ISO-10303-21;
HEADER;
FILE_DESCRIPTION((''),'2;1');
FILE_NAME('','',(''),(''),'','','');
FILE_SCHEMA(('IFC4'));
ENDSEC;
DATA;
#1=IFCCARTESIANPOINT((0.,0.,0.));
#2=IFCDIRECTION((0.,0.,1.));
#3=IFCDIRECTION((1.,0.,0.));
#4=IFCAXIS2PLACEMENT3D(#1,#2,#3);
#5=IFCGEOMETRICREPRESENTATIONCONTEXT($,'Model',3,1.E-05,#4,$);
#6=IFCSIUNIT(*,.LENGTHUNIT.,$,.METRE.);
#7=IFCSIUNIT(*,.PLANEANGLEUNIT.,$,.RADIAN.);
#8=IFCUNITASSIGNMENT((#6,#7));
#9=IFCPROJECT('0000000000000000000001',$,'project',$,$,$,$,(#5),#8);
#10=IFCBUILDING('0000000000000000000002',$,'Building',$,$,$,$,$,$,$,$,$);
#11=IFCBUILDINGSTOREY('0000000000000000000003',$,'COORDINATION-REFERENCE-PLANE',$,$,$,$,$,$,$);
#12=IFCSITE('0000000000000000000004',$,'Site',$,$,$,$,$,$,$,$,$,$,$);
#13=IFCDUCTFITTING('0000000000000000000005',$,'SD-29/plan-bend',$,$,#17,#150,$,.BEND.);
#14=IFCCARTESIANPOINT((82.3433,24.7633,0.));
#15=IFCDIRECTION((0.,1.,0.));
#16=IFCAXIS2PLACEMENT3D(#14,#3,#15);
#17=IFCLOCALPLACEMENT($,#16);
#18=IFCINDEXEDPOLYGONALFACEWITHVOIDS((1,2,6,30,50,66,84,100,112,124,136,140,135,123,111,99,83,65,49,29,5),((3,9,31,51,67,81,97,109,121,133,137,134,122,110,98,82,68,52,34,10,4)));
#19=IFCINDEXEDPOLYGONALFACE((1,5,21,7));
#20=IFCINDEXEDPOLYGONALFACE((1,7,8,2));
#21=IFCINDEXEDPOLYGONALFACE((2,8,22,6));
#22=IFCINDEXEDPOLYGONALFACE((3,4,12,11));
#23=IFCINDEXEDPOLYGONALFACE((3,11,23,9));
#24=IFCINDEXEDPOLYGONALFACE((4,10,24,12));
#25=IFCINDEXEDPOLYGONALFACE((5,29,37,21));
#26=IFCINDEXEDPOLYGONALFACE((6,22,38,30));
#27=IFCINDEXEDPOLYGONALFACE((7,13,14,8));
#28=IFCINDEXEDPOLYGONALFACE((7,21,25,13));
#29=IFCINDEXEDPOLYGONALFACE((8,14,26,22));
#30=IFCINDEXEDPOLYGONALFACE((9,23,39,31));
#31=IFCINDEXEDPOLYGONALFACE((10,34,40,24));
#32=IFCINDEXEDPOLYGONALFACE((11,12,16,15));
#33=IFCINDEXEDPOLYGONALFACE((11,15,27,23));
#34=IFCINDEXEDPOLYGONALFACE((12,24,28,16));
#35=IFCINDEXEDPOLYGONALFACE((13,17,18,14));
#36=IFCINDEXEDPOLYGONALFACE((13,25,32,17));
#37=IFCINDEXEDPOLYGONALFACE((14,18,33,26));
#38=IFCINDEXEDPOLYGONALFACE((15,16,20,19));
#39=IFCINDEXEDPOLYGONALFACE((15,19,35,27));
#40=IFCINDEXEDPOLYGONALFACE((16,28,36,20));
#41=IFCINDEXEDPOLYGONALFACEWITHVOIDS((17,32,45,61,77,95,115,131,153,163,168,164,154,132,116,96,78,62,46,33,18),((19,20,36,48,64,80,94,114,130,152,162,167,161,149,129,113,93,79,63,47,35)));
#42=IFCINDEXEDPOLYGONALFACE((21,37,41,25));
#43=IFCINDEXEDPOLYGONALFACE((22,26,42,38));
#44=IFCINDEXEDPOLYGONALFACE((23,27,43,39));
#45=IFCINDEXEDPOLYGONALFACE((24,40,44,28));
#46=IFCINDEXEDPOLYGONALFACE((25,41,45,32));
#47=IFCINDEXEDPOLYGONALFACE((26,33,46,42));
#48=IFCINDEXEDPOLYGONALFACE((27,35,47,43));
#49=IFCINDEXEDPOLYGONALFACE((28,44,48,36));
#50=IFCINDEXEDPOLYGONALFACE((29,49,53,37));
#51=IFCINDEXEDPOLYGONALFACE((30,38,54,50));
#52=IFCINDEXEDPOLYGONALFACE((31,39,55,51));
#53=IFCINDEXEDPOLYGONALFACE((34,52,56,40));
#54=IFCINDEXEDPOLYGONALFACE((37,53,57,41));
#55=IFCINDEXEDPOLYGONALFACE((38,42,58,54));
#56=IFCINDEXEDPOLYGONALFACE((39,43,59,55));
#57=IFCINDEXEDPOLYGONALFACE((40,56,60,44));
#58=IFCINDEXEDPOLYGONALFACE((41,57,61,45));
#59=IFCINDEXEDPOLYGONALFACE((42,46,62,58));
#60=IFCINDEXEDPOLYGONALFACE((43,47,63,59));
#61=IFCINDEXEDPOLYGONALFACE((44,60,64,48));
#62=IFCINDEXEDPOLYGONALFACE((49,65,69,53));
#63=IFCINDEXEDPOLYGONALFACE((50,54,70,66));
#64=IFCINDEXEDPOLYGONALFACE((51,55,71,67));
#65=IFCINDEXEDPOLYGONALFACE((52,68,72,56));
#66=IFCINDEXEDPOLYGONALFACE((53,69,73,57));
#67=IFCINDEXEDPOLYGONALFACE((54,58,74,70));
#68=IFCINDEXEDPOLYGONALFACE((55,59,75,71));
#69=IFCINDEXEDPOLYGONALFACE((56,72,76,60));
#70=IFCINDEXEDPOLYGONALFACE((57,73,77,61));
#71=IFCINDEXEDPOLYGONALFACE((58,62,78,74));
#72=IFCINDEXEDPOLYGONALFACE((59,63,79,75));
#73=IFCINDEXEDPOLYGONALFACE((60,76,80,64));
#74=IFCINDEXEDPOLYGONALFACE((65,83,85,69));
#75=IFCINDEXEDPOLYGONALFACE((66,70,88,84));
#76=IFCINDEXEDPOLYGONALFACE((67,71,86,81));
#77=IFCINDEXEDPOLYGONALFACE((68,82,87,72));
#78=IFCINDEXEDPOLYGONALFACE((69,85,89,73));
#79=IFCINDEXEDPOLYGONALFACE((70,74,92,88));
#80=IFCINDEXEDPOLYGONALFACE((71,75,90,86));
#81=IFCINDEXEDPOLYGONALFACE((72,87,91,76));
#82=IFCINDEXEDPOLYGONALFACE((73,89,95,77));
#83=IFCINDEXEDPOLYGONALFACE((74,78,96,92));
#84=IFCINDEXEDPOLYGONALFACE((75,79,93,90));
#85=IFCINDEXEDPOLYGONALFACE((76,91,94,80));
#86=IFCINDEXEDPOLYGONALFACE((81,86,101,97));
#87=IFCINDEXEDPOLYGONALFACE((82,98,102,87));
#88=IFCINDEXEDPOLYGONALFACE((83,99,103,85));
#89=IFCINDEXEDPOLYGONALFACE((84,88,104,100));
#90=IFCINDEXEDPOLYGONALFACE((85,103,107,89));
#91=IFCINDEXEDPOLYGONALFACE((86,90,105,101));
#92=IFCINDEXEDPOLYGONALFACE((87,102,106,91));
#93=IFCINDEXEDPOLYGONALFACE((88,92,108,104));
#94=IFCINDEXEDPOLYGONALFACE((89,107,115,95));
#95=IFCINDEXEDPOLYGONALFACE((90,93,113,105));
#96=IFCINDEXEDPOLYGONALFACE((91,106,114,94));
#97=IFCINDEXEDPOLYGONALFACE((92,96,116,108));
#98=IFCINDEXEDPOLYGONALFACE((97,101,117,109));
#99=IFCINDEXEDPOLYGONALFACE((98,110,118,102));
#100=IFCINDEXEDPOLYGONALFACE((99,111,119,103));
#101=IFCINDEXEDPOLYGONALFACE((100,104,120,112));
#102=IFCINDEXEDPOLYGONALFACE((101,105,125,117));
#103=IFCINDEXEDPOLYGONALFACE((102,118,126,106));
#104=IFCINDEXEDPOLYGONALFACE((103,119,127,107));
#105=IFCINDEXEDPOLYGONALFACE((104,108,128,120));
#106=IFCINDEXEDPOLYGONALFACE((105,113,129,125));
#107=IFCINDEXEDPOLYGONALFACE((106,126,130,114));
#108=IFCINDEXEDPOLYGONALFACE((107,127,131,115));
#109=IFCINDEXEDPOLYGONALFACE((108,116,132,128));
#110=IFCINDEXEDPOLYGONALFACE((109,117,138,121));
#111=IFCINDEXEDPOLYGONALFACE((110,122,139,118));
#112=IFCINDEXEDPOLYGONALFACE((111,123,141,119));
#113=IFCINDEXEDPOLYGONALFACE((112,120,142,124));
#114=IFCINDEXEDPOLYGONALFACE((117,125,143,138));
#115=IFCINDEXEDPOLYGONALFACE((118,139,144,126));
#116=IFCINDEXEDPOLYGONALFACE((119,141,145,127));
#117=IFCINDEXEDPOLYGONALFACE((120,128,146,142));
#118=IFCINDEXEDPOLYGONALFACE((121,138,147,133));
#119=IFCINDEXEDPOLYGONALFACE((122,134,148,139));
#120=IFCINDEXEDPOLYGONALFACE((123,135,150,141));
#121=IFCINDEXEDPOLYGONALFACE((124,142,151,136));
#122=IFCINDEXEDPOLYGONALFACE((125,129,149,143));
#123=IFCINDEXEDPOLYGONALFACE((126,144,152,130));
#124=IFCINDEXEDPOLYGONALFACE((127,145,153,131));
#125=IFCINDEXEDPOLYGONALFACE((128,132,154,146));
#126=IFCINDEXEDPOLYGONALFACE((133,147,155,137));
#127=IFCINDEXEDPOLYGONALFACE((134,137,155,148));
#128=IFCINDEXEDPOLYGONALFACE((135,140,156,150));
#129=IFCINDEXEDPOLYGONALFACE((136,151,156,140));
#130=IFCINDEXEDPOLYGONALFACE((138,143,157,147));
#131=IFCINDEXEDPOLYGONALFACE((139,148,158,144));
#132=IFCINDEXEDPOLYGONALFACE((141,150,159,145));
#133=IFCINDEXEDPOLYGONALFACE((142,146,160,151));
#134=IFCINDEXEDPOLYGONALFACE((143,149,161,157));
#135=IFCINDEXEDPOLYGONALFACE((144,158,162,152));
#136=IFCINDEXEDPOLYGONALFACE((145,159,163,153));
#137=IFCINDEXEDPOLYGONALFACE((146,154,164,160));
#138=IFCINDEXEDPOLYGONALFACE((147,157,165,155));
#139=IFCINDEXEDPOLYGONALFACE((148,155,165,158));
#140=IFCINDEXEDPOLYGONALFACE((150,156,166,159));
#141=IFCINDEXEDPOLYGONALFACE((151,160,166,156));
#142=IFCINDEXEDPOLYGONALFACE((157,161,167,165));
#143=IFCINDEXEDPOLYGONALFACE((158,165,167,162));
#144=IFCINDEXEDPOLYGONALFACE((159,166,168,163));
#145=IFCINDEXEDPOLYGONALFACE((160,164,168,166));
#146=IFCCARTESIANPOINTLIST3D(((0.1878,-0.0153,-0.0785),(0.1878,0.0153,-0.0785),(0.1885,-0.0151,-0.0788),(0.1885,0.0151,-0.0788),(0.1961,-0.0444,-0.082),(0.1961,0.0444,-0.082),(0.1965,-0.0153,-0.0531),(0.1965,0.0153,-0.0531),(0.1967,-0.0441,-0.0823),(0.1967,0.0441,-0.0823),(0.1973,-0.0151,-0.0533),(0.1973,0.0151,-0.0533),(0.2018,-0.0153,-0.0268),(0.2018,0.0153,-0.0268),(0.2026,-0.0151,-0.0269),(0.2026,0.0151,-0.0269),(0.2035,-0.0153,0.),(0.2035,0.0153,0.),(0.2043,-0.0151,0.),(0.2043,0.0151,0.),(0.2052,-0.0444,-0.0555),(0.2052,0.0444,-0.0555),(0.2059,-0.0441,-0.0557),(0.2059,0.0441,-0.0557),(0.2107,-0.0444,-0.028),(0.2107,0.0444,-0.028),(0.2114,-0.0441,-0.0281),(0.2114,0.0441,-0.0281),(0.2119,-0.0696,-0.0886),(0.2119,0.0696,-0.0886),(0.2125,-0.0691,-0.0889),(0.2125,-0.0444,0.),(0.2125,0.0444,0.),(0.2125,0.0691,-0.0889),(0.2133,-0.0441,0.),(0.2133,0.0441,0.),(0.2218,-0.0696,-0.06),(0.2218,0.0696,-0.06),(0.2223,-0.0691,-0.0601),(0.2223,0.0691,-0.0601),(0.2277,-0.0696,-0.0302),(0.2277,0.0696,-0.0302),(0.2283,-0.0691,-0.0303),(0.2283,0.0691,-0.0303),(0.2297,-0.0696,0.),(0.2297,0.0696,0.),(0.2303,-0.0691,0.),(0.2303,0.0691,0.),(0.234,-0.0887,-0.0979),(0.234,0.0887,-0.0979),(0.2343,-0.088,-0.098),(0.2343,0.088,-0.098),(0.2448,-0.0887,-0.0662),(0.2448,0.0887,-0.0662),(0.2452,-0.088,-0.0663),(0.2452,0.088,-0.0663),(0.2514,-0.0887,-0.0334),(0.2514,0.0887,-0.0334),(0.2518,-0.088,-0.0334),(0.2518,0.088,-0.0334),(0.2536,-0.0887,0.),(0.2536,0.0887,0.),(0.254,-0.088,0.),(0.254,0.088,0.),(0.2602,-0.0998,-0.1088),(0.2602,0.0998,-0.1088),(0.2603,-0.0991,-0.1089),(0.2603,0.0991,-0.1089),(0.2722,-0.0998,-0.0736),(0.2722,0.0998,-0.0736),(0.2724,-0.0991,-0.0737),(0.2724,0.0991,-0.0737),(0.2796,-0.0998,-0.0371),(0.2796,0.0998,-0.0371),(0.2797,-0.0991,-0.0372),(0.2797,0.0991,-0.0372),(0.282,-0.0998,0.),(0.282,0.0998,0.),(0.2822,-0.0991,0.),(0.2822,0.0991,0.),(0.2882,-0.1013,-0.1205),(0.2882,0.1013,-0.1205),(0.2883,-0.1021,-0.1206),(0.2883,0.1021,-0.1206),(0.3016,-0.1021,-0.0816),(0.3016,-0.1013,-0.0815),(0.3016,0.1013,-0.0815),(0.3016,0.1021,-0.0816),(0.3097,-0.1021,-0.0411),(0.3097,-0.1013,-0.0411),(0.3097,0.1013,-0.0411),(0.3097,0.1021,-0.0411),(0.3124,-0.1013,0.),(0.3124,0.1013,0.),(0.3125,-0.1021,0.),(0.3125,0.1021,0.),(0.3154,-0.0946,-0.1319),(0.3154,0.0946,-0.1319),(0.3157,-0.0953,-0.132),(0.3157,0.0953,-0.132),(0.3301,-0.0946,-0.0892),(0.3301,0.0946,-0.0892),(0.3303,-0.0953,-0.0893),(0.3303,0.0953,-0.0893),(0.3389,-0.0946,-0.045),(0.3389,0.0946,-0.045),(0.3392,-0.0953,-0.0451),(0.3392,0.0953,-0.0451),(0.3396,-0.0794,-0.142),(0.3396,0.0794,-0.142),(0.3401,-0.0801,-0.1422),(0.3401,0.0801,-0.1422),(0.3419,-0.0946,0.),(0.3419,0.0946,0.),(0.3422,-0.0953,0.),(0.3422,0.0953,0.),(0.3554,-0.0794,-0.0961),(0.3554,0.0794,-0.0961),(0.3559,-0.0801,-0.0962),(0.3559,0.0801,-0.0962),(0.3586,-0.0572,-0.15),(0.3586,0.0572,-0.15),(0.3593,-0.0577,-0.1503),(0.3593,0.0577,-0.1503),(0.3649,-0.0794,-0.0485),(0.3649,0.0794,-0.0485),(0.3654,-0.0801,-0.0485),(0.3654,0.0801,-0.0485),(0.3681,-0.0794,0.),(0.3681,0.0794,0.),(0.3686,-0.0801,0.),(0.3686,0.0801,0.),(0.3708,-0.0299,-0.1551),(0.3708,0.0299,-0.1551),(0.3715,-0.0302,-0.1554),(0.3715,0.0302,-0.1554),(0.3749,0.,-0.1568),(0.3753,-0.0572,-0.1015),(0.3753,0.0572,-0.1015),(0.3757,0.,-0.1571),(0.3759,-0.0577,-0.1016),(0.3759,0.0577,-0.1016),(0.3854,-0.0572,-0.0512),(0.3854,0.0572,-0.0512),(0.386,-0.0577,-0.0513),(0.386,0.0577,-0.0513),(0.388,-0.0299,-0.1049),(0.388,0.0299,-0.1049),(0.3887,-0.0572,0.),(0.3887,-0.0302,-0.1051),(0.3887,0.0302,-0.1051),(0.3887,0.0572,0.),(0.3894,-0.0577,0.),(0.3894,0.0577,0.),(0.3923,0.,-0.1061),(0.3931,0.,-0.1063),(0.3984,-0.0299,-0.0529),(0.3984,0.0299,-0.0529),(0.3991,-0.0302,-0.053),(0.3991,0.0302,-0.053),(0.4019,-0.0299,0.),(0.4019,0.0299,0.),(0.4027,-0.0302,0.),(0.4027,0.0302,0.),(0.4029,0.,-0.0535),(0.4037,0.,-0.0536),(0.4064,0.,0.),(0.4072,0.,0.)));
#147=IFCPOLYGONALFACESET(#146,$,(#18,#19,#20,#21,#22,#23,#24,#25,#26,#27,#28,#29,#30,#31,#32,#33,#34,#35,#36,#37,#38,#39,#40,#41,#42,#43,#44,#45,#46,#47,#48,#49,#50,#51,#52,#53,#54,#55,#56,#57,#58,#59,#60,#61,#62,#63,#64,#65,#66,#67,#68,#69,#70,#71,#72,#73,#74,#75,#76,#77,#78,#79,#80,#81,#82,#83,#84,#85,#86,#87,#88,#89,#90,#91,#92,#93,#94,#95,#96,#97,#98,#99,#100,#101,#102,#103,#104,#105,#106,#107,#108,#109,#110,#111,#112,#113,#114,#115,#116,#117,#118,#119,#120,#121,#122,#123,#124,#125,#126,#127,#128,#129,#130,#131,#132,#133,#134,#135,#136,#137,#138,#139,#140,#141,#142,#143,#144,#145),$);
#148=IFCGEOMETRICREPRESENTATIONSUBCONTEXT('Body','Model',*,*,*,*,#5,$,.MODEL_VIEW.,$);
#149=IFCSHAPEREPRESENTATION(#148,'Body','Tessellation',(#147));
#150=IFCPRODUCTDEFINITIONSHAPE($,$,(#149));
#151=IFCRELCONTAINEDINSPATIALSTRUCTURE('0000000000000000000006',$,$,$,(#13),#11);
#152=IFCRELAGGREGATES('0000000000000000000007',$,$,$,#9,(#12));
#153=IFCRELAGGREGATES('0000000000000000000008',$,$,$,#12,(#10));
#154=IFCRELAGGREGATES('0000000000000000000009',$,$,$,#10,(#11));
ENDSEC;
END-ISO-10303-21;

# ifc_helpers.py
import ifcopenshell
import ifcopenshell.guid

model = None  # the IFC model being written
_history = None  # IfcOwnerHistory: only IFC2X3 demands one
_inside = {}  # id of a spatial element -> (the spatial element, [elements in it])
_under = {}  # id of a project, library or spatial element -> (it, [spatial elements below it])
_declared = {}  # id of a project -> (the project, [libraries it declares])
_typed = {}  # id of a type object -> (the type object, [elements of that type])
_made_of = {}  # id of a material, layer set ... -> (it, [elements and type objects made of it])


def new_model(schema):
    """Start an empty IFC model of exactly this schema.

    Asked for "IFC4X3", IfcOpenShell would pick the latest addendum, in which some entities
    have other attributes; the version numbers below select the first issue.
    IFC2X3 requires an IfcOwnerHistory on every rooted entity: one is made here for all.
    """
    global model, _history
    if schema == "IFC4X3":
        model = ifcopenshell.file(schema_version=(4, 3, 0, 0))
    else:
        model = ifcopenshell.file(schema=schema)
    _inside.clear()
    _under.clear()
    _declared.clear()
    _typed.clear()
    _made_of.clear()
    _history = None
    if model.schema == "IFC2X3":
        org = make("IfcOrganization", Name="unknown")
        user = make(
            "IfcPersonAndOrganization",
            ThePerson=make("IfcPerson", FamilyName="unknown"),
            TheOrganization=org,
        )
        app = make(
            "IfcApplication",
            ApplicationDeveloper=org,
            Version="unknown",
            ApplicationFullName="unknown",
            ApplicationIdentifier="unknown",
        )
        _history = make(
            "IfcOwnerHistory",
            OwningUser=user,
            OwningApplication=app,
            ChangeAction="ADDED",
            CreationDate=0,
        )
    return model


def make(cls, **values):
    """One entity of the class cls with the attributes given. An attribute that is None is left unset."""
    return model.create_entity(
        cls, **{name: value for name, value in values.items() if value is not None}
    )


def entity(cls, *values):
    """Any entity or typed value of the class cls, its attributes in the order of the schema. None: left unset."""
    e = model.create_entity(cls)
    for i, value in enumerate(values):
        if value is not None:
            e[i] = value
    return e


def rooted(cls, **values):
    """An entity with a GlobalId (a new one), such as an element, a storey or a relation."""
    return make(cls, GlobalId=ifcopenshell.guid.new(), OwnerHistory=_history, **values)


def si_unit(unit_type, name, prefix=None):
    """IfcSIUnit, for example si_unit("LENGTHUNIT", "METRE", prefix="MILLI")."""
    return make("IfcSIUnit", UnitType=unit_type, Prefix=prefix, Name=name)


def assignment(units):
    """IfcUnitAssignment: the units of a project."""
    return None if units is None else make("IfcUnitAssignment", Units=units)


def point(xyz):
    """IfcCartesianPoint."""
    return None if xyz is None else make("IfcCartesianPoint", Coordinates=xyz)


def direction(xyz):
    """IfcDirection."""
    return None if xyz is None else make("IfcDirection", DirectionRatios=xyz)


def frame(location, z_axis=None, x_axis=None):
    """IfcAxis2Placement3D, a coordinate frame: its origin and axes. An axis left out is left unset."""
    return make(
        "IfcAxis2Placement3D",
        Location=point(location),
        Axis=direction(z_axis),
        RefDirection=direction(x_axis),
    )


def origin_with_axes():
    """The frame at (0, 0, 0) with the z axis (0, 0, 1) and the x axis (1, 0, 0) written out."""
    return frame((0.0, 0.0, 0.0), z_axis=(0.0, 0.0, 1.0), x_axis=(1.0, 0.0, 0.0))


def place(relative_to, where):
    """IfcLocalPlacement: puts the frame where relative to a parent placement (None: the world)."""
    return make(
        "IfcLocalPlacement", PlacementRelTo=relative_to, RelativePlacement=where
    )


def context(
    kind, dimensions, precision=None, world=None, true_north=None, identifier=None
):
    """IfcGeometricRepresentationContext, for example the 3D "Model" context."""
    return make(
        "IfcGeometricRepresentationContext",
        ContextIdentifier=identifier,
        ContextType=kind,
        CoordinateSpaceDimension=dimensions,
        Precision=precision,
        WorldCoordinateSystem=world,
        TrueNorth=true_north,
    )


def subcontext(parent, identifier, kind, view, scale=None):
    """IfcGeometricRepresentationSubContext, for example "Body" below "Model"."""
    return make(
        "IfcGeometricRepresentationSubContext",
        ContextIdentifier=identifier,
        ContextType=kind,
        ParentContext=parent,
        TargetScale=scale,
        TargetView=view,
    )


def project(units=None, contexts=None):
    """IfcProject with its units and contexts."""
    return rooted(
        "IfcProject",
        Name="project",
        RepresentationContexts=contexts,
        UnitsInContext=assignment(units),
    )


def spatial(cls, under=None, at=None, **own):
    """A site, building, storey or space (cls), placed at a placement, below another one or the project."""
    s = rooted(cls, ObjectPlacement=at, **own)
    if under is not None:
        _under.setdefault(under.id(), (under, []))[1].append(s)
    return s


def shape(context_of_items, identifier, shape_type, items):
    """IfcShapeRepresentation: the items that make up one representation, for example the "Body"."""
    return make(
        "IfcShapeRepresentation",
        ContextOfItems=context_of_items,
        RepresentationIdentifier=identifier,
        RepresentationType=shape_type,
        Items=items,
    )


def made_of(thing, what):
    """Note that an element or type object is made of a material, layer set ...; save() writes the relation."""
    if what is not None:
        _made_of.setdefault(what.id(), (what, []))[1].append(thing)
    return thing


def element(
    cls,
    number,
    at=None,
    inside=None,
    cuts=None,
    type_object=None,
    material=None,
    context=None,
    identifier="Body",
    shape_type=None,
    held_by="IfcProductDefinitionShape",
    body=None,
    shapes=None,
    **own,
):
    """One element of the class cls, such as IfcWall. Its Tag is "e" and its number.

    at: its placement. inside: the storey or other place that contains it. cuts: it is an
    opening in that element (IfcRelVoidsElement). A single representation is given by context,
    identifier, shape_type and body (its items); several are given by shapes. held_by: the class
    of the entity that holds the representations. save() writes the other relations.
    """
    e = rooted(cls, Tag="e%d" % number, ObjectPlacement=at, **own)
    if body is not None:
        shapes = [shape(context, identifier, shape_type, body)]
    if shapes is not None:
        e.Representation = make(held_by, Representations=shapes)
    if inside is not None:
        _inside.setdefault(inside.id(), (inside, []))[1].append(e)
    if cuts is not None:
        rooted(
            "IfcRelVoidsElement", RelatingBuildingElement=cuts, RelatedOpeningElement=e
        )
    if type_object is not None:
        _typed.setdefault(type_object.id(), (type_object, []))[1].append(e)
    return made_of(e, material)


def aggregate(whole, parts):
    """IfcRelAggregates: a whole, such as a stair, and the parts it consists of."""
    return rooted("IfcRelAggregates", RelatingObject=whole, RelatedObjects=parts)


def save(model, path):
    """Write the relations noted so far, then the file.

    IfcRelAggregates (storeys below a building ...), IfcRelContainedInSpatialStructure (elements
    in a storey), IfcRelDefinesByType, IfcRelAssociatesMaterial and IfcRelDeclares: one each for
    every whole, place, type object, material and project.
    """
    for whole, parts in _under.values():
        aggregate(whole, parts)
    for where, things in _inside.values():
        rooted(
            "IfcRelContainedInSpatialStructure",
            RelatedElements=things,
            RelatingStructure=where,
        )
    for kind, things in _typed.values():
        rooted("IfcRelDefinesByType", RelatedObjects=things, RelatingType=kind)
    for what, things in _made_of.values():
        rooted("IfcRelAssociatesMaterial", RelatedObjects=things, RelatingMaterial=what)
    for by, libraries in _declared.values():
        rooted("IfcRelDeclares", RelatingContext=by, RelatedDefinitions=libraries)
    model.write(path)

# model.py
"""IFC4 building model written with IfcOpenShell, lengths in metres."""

from ifc_helpers import new_model, entity, si_unit, frame, origin_with_axes, place, context, subcontext, project, spatial, element, save


model = new_model("IFC4")

# Units and contexts
model_context_1 = context("Model", 3, precision=1e-05, world=origin_with_axes())
body_context_1 = subcontext(model_context_1, "Body", "Model", "MODEL_VIEW")
ifc_project = project(units=[si_unit("LENGTHUNIT", "METRE"), si_unit("PLANEANGLEUNIT", "RADIAN")], contexts=[model_context_1])

# Site, building, storey
site = spatial("IfcSite", under=ifc_project, Name="Site")
building = spatial("IfcBuilding", under=site, Name="Building")
storey = spatial("IfcBuildingStorey", under=building, Name="COORDINATION-REFERENCE-PLANE")

# Duct fitting
duct_fitting_1_placement = place(None, frame((82.3433, 24.7633, 0.0), z_axis=(1.0, 0.0, 0.0), x_axis=(0.0, 1.0, 0.0)))
element("IfcDuctFitting", 1, at=duct_fitting_1_placement, inside=storey, Name="SD-29/plan-bend", PredefinedType="BEND", context=body_context_1, shape_type="SweptSolid", body=[
    entity("IfcRevolvedAreaSolid", entity("IfcCircleHollowProfileDef", "AREA", None, entity("IfcAxis2Placement2D", entity("IfcCartesianPoint", [0.3048, 0.0])), 0.1024, 0.0008), entity("IfcAxis2Placement3D", entity("IfcCartesianPoint", [0.0, 0.0, 0.0]), entity("IfcDirection", [0.0, 0.0, 1.0]), entity("IfcDirection", [1.0, 0.0, 0.0])), entity("IfcAxis1Placement", entity("IfcCartesianPoint", [0.0, 0.0, 0.0]), entity("IfcDirection", [0.0, 1.0, 0.0])), 0.396124),
])

save(model, "model.ifc")
